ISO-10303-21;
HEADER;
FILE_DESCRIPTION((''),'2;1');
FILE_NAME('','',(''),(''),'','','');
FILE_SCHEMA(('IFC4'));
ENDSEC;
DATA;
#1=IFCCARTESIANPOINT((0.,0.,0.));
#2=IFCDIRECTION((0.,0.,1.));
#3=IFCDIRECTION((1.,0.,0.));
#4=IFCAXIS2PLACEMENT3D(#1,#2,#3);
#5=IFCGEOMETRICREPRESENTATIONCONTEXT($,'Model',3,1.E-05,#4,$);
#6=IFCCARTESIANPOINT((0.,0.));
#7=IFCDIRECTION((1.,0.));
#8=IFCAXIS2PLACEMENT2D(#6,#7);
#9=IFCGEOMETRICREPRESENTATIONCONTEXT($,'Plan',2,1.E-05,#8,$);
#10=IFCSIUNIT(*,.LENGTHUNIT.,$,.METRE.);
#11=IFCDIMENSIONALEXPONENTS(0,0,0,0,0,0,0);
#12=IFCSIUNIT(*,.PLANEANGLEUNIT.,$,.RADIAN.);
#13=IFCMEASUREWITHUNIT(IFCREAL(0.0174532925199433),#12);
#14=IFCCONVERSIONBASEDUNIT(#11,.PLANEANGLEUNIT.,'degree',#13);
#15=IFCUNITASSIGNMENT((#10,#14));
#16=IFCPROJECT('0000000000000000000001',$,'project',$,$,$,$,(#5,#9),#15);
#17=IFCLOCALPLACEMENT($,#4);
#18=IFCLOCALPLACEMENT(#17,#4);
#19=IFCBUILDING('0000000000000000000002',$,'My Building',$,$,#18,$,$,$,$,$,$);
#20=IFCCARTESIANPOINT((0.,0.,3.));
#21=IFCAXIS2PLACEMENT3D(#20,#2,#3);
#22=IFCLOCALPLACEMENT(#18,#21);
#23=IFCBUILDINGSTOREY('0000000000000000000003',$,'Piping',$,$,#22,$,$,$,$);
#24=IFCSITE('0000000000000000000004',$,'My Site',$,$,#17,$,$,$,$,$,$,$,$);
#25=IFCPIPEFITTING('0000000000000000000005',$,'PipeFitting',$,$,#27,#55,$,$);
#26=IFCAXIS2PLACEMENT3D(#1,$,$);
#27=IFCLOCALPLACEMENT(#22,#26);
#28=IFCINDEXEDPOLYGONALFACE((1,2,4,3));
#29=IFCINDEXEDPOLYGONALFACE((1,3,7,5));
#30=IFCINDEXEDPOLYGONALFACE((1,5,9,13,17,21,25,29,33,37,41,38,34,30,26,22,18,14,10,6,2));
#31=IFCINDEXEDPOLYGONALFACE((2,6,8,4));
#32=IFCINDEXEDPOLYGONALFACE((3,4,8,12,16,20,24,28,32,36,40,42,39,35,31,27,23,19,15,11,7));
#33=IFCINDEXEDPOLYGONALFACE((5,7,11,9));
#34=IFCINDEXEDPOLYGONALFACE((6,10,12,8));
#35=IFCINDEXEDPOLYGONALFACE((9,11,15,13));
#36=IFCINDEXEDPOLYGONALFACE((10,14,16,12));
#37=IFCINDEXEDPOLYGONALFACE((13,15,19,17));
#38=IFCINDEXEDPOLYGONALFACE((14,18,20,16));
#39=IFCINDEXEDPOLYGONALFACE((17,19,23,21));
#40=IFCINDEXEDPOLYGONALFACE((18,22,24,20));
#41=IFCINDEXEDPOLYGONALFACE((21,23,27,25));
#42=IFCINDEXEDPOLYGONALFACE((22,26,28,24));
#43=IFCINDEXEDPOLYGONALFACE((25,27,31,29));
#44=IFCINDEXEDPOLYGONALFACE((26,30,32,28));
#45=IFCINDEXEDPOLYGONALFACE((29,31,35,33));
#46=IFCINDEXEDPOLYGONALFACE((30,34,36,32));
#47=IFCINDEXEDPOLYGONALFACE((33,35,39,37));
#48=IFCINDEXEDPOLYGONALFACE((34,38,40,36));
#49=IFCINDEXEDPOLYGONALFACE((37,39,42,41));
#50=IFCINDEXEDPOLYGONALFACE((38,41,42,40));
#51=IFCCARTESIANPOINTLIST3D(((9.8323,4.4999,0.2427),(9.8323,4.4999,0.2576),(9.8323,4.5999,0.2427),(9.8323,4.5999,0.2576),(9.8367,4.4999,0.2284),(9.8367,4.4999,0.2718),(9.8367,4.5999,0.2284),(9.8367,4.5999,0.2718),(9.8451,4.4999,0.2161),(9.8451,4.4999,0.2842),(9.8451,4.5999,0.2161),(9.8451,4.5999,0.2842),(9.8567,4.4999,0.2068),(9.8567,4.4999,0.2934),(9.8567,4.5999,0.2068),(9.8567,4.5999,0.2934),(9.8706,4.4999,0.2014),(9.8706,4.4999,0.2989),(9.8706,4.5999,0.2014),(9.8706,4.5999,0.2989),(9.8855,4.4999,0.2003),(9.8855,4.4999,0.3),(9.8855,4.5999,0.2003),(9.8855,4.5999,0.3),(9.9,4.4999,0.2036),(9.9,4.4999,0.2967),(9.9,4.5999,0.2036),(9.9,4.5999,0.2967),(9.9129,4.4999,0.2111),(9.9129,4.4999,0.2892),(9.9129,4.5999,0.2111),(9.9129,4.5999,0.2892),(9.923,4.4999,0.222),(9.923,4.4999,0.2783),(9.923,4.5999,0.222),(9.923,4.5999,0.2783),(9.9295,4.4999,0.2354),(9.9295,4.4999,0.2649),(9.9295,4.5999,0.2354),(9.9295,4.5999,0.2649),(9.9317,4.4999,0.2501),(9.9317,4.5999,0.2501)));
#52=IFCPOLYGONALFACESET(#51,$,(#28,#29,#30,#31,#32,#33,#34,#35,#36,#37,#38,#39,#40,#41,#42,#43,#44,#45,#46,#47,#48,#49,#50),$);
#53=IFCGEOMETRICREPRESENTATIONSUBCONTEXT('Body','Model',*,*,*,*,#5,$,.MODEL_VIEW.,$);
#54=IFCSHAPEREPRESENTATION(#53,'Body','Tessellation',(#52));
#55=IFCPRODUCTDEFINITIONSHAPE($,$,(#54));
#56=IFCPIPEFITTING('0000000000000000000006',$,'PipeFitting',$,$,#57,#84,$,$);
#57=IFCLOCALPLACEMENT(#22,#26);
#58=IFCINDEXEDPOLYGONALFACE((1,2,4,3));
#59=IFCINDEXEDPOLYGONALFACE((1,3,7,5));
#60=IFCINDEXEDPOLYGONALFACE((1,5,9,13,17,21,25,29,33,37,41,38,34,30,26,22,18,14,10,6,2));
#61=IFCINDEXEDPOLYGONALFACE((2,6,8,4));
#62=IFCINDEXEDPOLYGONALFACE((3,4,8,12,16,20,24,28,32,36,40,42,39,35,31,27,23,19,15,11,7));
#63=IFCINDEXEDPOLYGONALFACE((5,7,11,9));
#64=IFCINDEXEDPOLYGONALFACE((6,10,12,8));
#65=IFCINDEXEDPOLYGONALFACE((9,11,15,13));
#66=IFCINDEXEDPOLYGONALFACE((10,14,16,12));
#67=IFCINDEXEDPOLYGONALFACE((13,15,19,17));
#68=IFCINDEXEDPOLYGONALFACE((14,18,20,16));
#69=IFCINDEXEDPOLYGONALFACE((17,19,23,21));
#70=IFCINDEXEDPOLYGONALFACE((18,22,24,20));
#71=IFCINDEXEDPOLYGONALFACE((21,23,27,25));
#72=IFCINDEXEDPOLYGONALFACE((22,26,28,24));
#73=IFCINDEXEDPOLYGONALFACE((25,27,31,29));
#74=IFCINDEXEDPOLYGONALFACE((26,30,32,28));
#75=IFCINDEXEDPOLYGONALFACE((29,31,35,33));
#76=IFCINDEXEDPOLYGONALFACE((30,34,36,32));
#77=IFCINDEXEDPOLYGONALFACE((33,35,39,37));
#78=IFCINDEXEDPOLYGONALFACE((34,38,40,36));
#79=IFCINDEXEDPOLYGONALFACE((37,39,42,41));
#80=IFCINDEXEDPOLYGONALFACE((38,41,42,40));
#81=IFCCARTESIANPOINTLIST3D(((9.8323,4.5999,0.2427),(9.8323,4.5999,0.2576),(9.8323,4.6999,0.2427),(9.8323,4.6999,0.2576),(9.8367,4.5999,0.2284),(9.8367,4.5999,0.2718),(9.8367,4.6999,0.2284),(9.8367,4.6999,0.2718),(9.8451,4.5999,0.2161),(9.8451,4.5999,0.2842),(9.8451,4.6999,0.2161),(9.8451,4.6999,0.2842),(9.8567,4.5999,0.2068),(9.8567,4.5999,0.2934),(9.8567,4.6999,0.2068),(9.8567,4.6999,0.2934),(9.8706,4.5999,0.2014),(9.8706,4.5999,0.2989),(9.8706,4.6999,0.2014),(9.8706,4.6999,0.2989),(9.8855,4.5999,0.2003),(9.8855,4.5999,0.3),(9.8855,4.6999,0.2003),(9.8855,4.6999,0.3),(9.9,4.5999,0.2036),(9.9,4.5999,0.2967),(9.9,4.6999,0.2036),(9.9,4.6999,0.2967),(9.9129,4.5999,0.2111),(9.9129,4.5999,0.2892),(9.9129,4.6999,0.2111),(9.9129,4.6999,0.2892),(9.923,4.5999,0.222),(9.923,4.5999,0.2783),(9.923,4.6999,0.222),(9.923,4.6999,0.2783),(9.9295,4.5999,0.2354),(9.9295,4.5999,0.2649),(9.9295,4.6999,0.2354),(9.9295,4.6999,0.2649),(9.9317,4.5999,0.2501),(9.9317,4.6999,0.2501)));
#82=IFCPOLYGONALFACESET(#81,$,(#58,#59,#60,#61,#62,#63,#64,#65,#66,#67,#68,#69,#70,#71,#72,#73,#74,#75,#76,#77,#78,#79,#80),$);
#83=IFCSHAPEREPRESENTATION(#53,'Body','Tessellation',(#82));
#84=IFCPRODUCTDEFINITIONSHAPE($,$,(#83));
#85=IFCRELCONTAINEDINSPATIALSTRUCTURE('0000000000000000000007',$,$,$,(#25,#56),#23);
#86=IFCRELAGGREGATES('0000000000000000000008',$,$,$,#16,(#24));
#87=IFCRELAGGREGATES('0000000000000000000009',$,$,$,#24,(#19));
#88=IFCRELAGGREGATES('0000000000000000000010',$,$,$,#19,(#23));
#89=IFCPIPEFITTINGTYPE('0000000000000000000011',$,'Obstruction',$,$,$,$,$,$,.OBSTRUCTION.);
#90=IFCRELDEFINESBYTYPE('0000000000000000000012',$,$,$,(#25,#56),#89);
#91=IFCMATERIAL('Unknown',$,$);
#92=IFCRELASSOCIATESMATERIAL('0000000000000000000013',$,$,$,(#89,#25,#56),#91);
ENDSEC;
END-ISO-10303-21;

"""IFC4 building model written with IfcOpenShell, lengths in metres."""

from ifc_helpers import new_model, entity, si_unit, converted_unit, frame, origin_with_axes, origin_2d_with_axis, place, context, subcontext, project, spatial, circle, extrude, material, material_profile, profile_set, profile_usage, type_object, element, save


model = new_model("IFC4")

# Units and contexts
model_context = context("Model", 3, precision=1e-05, world=origin_with_axes())
plan_context = context("Plan", 2, precision=1e-05, world=origin_2d_with_axis())
body_context = subcontext(model_context, "Body", "Model", "MODEL_VIEW")
ifc_project = project(units=[si_unit("LENGTHUNIT", "METRE"), converted_unit("PLANEANGLEUNIT", "degree", entity("IfcReal", 0.0174532925199433), si_unit("PLANEANGLEUNIT", "RADIAN"), dimensions=[0, 0, 0, 0, 0, 0, 0])], contexts=[model_context, plan_context])

# Site, building, storey
site_placement = place(None, origin_with_axes())
site = spatial("IfcSite", under=ifc_project, at=site_placement, Name="My Site")
building_placement = place(site_placement, origin_with_axes())
building = spatial("IfcBuilding", under=site, at=building_placement, Name="My Building")
storey_placement = place(building_placement, frame((0.0, 0.0, 3.0), z_axis=(0.0, 0.0, 1.0), x_axis=(1.0, 0.0, 0.0)))
storey = spatial("IfcBuildingStorey", under=building, at=storey_placement, Name="Piping")

# Shared definitions
ifc_material = material(Name="Unknown")

# Pipe fittings
ifc_material_profile_1 = material_profile(ifc_material, circle(Radius=0.05))
ifc_profile_set_1 = profile_set([ifc_material_profile_1])
pipe_fitting_type_1 = type_object("IfcPipeFittingType", Name="Obstruction", PredefinedType="OBSTRUCTION", material=ifc_profile_set_1)
ifc_profile_usage_1 = profile_usage(ifc_profile_set_1, cardinal=5)
pipe_fitting_1_placement = place(storey_placement, frame((9.8817, 4.5999, 0.2501), z_axis=(0.0, -1.0, 0.000008), x_axis=(1.0, 0.0, 0.0)))
element("IfcPipeFitting", 1, at=pipe_fitting_1_placement, inside=storey, type_object=pipe_fitting_type_1, material=ifc_profile_usage_1, Name="PipeFitting", context=body_context, shape_type="SweptSolid", body=[
    extrude(circle(Radius=0.05), origin_with_axes(), (0.0, 0.0, 1.0), 0.1),
])
ifc_profile_usage_2 = profile_usage(ifc_profile_set_1, cardinal=5)
pipe_fitting_2_placement = place(storey_placement, frame((9.8817, 4.5999, 0.2501), z_axis=(0.0, 1.0, -0.000008), x_axis=(1.0, 0.0, 0.0)))
element("IfcPipeFitting", 2, at=pipe_fitting_2_placement, inside=storey, type_object=pipe_fitting_type_1, material=ifc_profile_usage_2, Name="PipeFitting", context=body_context, shape_type="SweptSolid", body=[
    extrude(circle(Radius=0.05), origin_with_axes(), (0.0, 0.0, 1.0), 0.1),
])

save(model, "model.ifc")
